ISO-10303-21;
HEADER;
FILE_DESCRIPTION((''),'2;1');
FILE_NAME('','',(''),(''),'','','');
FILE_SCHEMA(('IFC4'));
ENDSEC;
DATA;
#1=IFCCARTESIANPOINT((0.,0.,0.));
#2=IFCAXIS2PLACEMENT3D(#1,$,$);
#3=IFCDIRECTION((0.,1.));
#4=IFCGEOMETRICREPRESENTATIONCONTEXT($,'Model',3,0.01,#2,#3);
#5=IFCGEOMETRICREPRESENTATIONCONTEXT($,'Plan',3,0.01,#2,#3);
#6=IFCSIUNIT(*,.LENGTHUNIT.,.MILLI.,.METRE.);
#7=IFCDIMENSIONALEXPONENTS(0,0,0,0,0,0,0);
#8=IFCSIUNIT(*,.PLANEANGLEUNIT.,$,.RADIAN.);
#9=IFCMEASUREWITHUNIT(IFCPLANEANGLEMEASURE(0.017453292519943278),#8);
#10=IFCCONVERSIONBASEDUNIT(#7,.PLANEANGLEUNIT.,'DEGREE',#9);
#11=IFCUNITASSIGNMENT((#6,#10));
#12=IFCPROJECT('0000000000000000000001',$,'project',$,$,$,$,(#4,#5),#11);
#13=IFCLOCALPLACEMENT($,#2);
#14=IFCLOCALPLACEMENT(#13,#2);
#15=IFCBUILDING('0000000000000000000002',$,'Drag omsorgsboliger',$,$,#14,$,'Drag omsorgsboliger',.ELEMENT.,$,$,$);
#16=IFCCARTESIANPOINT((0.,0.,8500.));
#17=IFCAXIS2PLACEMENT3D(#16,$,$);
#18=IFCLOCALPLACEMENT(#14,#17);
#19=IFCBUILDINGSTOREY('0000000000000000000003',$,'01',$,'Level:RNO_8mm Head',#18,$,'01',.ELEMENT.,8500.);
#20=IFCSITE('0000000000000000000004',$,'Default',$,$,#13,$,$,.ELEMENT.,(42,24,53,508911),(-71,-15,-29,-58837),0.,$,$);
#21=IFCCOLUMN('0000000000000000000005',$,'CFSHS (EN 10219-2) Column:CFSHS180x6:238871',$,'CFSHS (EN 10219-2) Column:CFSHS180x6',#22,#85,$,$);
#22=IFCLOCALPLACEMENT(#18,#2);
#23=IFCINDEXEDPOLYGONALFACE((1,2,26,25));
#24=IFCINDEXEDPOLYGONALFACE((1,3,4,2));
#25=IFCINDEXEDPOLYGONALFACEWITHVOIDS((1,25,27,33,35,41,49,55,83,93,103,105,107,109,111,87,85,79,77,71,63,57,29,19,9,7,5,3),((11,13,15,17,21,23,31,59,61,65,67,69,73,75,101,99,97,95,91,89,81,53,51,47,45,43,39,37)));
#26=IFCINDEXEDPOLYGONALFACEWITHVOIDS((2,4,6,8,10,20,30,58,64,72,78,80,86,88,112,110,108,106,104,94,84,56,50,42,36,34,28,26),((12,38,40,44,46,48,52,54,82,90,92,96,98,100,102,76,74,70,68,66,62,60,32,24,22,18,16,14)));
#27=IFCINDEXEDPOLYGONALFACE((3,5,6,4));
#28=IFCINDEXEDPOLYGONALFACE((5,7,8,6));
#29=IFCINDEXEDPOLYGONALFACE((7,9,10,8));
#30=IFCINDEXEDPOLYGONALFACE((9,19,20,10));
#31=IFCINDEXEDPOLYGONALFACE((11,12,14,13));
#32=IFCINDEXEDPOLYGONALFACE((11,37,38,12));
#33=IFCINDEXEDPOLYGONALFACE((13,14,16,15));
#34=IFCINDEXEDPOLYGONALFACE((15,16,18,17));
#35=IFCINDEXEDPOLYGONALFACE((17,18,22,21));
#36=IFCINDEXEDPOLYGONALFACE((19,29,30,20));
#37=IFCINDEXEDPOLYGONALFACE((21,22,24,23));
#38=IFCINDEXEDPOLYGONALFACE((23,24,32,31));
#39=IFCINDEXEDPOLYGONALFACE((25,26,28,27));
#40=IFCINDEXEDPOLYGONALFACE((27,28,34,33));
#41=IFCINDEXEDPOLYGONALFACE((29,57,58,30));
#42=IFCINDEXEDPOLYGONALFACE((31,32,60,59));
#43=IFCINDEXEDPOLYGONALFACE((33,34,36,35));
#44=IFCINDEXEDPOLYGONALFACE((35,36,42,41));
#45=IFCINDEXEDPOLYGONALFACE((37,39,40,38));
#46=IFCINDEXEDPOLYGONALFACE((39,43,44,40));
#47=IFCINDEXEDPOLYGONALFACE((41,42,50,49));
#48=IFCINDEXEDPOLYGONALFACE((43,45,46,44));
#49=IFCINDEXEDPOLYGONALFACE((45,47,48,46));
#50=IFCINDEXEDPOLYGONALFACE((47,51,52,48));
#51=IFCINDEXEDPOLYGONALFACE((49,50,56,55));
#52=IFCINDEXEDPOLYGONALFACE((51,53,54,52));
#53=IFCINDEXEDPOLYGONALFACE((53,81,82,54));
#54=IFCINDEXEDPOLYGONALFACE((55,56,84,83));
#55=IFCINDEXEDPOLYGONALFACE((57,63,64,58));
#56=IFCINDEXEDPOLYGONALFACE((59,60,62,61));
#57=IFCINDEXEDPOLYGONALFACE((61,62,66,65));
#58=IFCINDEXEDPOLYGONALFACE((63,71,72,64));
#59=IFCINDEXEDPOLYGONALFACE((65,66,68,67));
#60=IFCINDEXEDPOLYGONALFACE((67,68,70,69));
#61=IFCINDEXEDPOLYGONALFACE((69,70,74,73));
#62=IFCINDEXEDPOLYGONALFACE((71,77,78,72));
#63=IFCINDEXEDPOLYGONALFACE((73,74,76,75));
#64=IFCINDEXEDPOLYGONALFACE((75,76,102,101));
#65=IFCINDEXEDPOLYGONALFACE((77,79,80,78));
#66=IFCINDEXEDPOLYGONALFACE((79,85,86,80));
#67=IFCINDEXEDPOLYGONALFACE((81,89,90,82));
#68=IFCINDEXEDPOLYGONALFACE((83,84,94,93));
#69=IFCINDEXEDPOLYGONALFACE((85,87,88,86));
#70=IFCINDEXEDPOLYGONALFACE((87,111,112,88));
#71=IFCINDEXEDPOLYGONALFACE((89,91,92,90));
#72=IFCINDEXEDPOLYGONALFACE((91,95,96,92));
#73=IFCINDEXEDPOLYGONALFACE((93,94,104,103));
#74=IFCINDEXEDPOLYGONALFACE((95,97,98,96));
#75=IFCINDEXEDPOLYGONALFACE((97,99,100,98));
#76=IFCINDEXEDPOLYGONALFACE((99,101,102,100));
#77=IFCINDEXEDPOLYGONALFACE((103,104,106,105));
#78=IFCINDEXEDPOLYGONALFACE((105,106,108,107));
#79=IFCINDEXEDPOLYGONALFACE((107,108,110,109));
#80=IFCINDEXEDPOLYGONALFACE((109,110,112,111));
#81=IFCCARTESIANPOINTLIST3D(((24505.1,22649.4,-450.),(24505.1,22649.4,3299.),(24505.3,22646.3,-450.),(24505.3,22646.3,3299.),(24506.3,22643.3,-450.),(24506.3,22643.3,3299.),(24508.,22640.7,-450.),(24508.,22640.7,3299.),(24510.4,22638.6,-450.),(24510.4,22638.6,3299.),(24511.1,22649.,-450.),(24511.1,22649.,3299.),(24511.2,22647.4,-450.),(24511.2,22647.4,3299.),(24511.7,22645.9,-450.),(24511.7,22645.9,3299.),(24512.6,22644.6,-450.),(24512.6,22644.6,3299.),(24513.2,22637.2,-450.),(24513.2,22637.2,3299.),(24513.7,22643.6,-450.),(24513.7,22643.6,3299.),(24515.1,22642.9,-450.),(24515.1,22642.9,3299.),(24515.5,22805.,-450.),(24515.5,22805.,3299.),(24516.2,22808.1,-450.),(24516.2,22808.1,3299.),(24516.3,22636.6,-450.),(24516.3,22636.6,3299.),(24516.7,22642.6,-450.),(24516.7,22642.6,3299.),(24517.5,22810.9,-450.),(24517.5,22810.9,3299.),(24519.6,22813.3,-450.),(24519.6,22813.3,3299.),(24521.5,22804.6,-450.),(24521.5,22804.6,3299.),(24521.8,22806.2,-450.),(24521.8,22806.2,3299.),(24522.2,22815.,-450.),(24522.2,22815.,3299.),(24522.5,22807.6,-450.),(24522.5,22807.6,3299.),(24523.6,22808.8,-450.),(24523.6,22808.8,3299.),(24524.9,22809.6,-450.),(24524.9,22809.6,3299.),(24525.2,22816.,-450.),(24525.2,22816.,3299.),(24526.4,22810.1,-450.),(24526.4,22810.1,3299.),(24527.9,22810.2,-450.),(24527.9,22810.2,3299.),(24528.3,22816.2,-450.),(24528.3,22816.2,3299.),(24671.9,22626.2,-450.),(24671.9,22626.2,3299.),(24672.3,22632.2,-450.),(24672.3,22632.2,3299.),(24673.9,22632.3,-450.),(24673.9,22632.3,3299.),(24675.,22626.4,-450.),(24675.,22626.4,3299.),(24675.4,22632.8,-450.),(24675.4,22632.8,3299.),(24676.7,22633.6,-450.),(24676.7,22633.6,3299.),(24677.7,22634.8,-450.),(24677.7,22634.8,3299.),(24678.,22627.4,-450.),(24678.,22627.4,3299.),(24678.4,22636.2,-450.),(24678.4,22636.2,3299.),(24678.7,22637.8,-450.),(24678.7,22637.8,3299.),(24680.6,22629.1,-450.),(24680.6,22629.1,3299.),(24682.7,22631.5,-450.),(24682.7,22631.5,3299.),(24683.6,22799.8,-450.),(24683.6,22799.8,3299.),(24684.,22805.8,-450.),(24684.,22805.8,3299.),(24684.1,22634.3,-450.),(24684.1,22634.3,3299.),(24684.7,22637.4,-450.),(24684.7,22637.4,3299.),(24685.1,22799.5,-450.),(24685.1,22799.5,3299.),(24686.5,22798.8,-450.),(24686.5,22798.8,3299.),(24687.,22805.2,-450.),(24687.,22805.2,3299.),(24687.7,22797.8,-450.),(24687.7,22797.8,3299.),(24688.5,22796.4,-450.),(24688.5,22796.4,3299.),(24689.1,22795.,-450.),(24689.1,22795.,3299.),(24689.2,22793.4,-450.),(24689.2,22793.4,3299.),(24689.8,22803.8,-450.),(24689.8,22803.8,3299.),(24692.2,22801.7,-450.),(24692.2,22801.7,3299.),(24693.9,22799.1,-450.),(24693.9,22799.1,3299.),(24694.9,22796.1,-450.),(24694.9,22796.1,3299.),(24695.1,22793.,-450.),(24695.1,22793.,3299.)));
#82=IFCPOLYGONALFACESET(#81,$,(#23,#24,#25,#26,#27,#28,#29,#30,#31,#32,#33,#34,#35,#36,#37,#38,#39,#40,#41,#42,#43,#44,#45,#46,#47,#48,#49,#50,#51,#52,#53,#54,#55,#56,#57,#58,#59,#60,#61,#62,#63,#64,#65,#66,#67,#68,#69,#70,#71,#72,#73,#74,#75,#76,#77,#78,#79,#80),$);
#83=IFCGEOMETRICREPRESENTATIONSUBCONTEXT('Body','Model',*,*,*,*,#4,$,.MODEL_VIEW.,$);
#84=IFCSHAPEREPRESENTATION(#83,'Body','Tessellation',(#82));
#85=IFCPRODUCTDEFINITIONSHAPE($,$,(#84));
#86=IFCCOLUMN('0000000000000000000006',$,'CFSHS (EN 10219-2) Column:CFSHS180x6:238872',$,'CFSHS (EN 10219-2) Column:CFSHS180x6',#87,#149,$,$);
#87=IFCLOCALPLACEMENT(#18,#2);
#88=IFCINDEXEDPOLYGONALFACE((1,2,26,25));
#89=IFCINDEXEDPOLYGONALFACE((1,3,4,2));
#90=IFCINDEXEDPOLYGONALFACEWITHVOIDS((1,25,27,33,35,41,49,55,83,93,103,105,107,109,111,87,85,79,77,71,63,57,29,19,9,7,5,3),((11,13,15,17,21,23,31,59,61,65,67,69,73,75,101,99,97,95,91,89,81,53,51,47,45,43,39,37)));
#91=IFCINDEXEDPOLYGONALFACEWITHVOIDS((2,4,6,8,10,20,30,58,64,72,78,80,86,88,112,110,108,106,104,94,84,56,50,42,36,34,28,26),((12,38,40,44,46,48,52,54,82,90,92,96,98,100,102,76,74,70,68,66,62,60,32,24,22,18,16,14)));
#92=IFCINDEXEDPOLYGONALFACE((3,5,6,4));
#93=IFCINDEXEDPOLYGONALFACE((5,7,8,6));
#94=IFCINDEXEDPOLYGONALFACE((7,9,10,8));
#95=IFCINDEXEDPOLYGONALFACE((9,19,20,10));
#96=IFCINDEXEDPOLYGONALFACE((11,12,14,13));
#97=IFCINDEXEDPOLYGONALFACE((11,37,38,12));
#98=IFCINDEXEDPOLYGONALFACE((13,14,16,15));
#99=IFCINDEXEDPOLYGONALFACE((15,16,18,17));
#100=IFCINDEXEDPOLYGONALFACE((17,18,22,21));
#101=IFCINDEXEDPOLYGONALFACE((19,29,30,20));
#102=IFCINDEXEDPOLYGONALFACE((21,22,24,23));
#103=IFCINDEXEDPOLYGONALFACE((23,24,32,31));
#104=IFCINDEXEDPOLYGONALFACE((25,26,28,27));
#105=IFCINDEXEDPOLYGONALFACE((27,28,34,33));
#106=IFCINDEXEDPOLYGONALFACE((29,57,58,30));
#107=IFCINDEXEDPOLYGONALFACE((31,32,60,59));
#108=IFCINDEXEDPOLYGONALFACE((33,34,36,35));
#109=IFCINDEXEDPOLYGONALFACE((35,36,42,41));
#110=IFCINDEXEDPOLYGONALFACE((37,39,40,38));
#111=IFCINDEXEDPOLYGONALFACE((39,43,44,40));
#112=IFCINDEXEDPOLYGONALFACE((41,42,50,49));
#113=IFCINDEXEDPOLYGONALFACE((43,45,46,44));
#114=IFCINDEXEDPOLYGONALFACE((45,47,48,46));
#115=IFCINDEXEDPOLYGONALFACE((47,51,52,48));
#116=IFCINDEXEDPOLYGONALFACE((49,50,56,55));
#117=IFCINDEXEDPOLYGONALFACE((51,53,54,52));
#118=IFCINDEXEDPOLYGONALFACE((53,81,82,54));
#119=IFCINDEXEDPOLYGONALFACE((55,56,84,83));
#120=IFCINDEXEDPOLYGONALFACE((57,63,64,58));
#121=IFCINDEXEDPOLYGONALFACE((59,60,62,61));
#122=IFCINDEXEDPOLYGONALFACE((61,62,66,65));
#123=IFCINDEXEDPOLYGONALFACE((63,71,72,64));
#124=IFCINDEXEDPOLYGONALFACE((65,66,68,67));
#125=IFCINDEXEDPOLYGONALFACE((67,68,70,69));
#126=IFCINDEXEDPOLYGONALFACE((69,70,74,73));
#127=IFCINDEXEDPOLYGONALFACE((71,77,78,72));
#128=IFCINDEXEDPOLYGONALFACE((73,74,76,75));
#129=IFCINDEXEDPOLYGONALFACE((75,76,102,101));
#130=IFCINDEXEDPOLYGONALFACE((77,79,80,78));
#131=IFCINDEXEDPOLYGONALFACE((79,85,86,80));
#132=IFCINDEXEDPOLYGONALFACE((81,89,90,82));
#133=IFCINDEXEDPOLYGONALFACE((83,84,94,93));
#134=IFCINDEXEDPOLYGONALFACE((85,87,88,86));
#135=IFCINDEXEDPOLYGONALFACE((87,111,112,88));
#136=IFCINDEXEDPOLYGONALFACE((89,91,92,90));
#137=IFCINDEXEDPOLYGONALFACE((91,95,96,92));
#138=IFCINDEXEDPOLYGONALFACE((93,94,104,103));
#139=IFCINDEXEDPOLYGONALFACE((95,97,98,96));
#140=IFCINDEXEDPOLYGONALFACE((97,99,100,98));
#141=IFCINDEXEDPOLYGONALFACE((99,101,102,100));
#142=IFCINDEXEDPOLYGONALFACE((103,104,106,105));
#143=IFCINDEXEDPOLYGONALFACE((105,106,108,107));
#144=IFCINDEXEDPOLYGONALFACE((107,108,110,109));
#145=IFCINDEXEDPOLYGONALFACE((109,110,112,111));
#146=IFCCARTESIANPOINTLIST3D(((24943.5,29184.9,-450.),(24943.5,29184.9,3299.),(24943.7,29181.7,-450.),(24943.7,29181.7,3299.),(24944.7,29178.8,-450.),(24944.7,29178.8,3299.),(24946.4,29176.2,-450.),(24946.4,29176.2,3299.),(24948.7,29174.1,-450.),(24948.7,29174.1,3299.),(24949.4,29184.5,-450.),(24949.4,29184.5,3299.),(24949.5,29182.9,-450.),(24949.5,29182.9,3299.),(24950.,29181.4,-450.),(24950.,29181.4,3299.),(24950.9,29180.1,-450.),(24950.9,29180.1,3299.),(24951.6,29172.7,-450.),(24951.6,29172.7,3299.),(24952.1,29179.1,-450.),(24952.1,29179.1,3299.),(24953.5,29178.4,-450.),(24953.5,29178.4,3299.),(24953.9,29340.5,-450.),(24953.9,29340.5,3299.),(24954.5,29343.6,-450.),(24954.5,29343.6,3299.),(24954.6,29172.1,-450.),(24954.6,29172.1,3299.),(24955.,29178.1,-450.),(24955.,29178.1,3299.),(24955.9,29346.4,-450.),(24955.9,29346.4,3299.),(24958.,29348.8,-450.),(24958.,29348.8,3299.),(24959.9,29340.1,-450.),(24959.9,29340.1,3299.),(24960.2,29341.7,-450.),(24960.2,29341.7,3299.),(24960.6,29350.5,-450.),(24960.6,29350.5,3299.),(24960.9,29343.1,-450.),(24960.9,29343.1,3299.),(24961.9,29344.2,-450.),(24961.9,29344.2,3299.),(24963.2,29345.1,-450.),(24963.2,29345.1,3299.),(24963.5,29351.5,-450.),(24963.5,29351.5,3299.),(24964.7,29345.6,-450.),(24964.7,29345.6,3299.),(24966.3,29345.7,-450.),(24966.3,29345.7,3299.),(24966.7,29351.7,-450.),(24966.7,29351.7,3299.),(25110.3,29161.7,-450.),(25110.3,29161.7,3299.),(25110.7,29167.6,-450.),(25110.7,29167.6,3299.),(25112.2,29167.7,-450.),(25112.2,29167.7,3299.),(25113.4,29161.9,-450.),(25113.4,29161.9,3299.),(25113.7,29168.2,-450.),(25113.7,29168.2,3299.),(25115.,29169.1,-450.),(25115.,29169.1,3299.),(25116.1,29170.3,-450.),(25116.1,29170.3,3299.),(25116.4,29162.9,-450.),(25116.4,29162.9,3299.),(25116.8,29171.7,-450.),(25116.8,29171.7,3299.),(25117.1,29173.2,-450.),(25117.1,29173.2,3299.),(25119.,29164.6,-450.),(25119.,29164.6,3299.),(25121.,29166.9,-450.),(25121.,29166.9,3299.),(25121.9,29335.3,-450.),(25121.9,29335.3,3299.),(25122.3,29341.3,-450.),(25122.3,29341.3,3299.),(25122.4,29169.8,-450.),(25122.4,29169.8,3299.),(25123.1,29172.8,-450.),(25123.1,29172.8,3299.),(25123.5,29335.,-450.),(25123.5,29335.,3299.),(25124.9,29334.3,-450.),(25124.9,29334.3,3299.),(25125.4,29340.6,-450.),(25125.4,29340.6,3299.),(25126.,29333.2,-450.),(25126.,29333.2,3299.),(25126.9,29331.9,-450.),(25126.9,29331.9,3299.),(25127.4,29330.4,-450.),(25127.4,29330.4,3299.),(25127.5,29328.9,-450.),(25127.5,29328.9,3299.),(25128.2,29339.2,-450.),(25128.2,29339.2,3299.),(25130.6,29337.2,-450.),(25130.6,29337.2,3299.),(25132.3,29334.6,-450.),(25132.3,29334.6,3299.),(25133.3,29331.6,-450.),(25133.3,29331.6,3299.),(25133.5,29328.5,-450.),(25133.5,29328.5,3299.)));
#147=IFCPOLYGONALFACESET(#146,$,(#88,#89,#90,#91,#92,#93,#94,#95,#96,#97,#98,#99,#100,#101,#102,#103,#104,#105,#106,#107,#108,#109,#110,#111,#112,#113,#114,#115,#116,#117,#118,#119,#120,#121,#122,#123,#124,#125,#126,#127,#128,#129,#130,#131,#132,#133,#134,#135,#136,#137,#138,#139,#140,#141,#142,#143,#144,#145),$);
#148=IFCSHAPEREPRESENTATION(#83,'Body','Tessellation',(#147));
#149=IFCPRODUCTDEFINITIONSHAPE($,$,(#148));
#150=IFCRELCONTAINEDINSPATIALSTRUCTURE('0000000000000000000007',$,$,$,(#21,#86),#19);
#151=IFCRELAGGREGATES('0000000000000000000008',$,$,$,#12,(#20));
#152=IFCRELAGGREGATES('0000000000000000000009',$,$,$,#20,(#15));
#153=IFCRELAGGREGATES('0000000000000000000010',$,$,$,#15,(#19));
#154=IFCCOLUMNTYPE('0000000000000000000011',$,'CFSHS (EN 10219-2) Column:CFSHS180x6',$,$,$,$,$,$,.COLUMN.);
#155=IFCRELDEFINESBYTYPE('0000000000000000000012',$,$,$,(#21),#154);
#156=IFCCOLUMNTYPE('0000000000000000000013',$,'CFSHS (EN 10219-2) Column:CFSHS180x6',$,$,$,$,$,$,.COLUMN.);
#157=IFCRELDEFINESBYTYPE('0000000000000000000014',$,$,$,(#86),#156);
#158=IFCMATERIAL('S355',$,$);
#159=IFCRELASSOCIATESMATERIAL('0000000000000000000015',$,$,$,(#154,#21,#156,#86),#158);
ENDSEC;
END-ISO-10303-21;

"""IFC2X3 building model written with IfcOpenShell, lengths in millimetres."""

from ifc_helpers import new_model, entity, si_unit, converted_unit, direction, frame, frame_2d, origin, place, context, subcontext, project, spatial, polyline, circle_curve, parameter, trimmed, segment, composite_curve, outline, extrude, source, transform, mapped, material, type_object, type_shapes, element, save


model = new_model("IFC2X3")

# Units and contexts
model_context = context("Model", 3, precision=0.01, world=origin(), true_north=direction((0.0, 1.0)))
plan_context = context("Plan", 3, precision=0.01, world=origin(), true_north=direction((0.0, 1.0)))
body_context = subcontext(model_context, "Body", "Model", "MODEL_VIEW")
ifc_project = project(units=[si_unit("LENGTHUNIT", "METRE", prefix="MILLI"), converted_unit("PLANEANGLEUNIT", "DEGREE", entity("IfcPlaneAngleMeasure", 0.017453292519943278), si_unit("PLANEANGLEUNIT", "RADIAN"), dimensions=[0, 0, 0, 0, 0, 0, 0])], contexts=[model_context, plan_context])

# Site, building, storey
site_placement = place(None, origin())
site = spatial("IfcSite", under=ifc_project, at=site_placement, Name="Default", CompositionType="ELEMENT", RefLatitude=(42, 24, 53, 508911), RefLongitude=(-71, -15, -29, -58837), RefElevation=0.0)
building_placement = place(site_placement, origin())
building = spatial("IfcBuilding", under=site, at=building_placement, Name="Drag omsorgsboliger", LongName="Drag omsorgsboliger", CompositionType="ELEMENT")
storey_placement = place(building_placement, frame((0.0, 0.0, 8500.0)))
storey = spatial("IfcBuildingStorey", under=building, at=storey_placement, Name="01", ObjectType="Level:RNO_8mm Head", LongName="01", CompositionType="ELEMENT", Elevation=8500.0)

# Columns
ifc_material = material(Name="S355")
column_type_1 = type_object("IfcColumnType", Name="CFSHS (EN 10219-2) Column:CFSHS180x6", PredefinedType="COLUMN", material=ifc_material)
shared_shape_1 = source(origin(), body_context, "Body", "SweptSolid", [
    extrude(outline(composite_curve([segment(polyline([(-78.0, -90.0), (78.0, -90.0)]), True, "CONTINUOUS"), segment(trimmed(circle_curve(frame_2d((78.0, -78.0), x_axis=(-1.0, 0.0)), 12.0), [parameter(90.0)], [parameter(180.0)], True, "PARAMETER"), True, "CONTINUOUS"), segment(polyline([(90.0, -78.0), (90.0, 78.0)]), True, "CONTINUOUS"), segment(trimmed(circle_curve(frame_2d((78.0, 78.0), x_axis=(-1.0, 0.0)), 12.0), [parameter(180.0)], [parameter(270.0)], True, "PARAMETER"), True, "CONTINUOUS"), segment(polyline([(78.0, 90.0), (-78.0, 90.0)]), True, "CONTINUOUS"), segment(trimmed(circle_curve(frame_2d((-78.0, 78.0), x_axis=(-1.0, 0.0)), 12.0), [parameter(270.0)], [parameter(360.0)], True, "PARAMETER"), True, "CONTINUOUS"), segment(polyline([(-90.0, 78.0), (-90.0, -78.0)]), True, "CONTINUOUS"), segment(trimmed(circle_curve(frame_2d((-78.0, -78.0), x_axis=(-1.0, 0.0)), 12.0), [parameter(360.0)], [parameter(90.0)], True, "PARAMETER"), True, "CONTINUOUS")], self_intersect=False), holes=[composite_curve([segment(trimmed(circle_curve(frame_2d((-78.0, -78.0), x_axis=(-1.0, 0.0)), 6.0), [parameter(360.0)], [parameter(90.0)], True, "PARAMETER"), False, "CONTINUOUS"), segment(polyline([(-84.0, -78.0), (-84.0, 78.0)]), True, "CONTINUOUS"), segment(trimmed(circle_curve(frame_2d((-78.0, 78.0), x_axis=(-1.0, 0.0)), 6.0), [parameter(270.0)], [parameter(360.0)], True, "PARAMETER"), False, "CONTINUOUS"), segment(polyline([(-78.0, 84.0), (78.0, 84.0)]), True, "CONTINUOUS"), segment(trimmed(circle_curve(frame_2d((78.0, 78.0), x_axis=(-1.0, 0.0)), 6.0), [parameter(180.0)], [parameter(270.0)], True, "PARAMETER"), False, "CONTINUOUS"), segment(polyline([(84.0, 78.0), (84.0, -78.0)]), True, "CONTINUOUS"), segment(trimmed(circle_curve(frame_2d((78.0, -78.0), x_axis=(-1.0, 0.0)), 6.0), [parameter(90.0)], [parameter(180.0)], True, "PARAMETER"), False, "CONTINUOUS"), segment(polyline([(78.0, -84.0), (-78.0, -84.0)]), True, "CONTINUOUS")], self_intersect=False)]), frame((24600.1, 22721.2, 8050.0), z_axis=(0.0, 0.0, 1.0), x_axis=(-0.997758, 0.066923, 0.0)), (0.0, 0.0, 1.0), 3749.0),
])
type_shapes(column_type_1, [shared_shape_1])
column_1_placement = place(storey_placement, frame((0.0, 0.0, -8500.0)))
element("IfcColumn", 1, at=column_1_placement, inside=storey, type_object=column_type_1, material=ifc_material, Name="CFSHS (EN 10219-2) Column:CFSHS180x6:238871", ObjectType="CFSHS (EN 10219-2) Column:CFSHS180x6", context=body_context, shape_type="MappedRepresentation", body=[
    mapped(shared_shape_1, transform((0.0, 0.0, 0.0), scale=1.0)),
])
column_type_2 = type_object("IfcColumnType", Name="CFSHS (EN 10219-2) Column:CFSHS180x6", PredefinedType="COLUMN", material=ifc_material)
shared_shape_2 = source(origin(), body_context, "Body", "SweptSolid", [
    extrude(outline(composite_curve([segment(polyline([(-78.0, -90.0), (78.0, -90.0)]), True, "CONTINUOUS"), segment(trimmed(circle_curve(frame_2d((78.0, -78.0), x_axis=(-1.0, 0.0)), 12.0), [parameter(90.0)], [parameter(180.0)], True, "PARAMETER"), True, "CONTINUOUS"), segment(polyline([(90.0, -78.0), (90.0, 78.0)]), True, "CONTINUOUS"), segment(trimmed(circle_curve(frame_2d((78.0, 78.0), x_axis=(-1.0, 0.0)), 12.0), [parameter(180.0)], [parameter(270.0)], True, "PARAMETER"), True, "CONTINUOUS"), segment(polyline([(78.0, 90.0), (-78.0, 90.0)]), True, "CONTINUOUS"), segment(trimmed(circle_curve(frame_2d((-78.0, 78.0), x_axis=(-1.0, 0.0)), 12.0), [parameter(270.0)], [parameter(360.0)], True, "PARAMETER"), True, "CONTINUOUS"), segment(polyline([(-90.0, 78.0), (-90.0, -78.0)]), True, "CONTINUOUS"), segment(trimmed(circle_curve(frame_2d((-78.0, -78.0), x_axis=(-1.0, 0.0)), 12.0), [parameter(360.0)], [parameter(90.0)], True, "PARAMETER"), True, "CONTINUOUS")], self_intersect=False), holes=[composite_curve([segment(trimmed(circle_curve(frame_2d((-78.0, -78.0), x_axis=(-1.0, 0.0)), 6.0), [parameter(360.0)], [parameter(90.0)], True, "PARAMETER"), False, "CONTINUOUS"), segment(polyline([(-84.0, -78.0), (-84.0, 78.0)]), True, "CONTINUOUS"), segment(trimmed(circle_curve(frame_2d((-78.0, 78.0), x_axis=(-1.0, 0.0)), 6.0), [parameter(270.0)], [parameter(360.0)], True, "PARAMETER"), False, "CONTINUOUS"), segment(polyline([(-78.0, 84.0), (78.0, 84.0)]), True, "CONTINUOUS"), segment(trimmed(circle_curve(frame_2d((78.0, 78.0), x_axis=(-1.0, 0.0)), 6.0), [parameter(180.0)], [parameter(270.0)], True, "PARAMETER"), False, "CONTINUOUS"), segment(polyline([(84.0, 78.0), (84.0, -78.0)]), True, "CONTINUOUS"), segment(trimmed(circle_curve(frame_2d((78.0, -78.0), x_axis=(-1.0, 0.0)), 6.0), [parameter(90.0)], [parameter(180.0)], True, "PARAMETER"), False, "CONTINUOUS"), segment(polyline([(78.0, -84.0), (-78.0, -84.0)]), True, "CONTINUOUS")], self_intersect=False)]), frame((25038.5, 29256.7, 8050.0), z_axis=(0.0, 0.0, 1.0), x_axis=(-0.997758, 0.066923, 0.0)), (0.0, 0.0, 1.0), 3749.0),
])
type_shapes(column_type_2, [shared_shape_2])
column_2_placement = place(storey_placement, frame((0.0, 0.0, -8500.0)))
element("IfcColumn", 2, at=column_2_placement, inside=storey, type_object=column_type_2, material=ifc_material, Name="CFSHS (EN 10219-2) Column:CFSHS180x6:238872", ObjectType="CFSHS (EN 10219-2) Column:CFSHS180x6", context=body_context, shape_type="MappedRepresentation", body=[
    mapped(shared_shape_2, transform((0.0, 0.0, 0.0), scale=1.0)),
])

save(model, "model.ifc")
